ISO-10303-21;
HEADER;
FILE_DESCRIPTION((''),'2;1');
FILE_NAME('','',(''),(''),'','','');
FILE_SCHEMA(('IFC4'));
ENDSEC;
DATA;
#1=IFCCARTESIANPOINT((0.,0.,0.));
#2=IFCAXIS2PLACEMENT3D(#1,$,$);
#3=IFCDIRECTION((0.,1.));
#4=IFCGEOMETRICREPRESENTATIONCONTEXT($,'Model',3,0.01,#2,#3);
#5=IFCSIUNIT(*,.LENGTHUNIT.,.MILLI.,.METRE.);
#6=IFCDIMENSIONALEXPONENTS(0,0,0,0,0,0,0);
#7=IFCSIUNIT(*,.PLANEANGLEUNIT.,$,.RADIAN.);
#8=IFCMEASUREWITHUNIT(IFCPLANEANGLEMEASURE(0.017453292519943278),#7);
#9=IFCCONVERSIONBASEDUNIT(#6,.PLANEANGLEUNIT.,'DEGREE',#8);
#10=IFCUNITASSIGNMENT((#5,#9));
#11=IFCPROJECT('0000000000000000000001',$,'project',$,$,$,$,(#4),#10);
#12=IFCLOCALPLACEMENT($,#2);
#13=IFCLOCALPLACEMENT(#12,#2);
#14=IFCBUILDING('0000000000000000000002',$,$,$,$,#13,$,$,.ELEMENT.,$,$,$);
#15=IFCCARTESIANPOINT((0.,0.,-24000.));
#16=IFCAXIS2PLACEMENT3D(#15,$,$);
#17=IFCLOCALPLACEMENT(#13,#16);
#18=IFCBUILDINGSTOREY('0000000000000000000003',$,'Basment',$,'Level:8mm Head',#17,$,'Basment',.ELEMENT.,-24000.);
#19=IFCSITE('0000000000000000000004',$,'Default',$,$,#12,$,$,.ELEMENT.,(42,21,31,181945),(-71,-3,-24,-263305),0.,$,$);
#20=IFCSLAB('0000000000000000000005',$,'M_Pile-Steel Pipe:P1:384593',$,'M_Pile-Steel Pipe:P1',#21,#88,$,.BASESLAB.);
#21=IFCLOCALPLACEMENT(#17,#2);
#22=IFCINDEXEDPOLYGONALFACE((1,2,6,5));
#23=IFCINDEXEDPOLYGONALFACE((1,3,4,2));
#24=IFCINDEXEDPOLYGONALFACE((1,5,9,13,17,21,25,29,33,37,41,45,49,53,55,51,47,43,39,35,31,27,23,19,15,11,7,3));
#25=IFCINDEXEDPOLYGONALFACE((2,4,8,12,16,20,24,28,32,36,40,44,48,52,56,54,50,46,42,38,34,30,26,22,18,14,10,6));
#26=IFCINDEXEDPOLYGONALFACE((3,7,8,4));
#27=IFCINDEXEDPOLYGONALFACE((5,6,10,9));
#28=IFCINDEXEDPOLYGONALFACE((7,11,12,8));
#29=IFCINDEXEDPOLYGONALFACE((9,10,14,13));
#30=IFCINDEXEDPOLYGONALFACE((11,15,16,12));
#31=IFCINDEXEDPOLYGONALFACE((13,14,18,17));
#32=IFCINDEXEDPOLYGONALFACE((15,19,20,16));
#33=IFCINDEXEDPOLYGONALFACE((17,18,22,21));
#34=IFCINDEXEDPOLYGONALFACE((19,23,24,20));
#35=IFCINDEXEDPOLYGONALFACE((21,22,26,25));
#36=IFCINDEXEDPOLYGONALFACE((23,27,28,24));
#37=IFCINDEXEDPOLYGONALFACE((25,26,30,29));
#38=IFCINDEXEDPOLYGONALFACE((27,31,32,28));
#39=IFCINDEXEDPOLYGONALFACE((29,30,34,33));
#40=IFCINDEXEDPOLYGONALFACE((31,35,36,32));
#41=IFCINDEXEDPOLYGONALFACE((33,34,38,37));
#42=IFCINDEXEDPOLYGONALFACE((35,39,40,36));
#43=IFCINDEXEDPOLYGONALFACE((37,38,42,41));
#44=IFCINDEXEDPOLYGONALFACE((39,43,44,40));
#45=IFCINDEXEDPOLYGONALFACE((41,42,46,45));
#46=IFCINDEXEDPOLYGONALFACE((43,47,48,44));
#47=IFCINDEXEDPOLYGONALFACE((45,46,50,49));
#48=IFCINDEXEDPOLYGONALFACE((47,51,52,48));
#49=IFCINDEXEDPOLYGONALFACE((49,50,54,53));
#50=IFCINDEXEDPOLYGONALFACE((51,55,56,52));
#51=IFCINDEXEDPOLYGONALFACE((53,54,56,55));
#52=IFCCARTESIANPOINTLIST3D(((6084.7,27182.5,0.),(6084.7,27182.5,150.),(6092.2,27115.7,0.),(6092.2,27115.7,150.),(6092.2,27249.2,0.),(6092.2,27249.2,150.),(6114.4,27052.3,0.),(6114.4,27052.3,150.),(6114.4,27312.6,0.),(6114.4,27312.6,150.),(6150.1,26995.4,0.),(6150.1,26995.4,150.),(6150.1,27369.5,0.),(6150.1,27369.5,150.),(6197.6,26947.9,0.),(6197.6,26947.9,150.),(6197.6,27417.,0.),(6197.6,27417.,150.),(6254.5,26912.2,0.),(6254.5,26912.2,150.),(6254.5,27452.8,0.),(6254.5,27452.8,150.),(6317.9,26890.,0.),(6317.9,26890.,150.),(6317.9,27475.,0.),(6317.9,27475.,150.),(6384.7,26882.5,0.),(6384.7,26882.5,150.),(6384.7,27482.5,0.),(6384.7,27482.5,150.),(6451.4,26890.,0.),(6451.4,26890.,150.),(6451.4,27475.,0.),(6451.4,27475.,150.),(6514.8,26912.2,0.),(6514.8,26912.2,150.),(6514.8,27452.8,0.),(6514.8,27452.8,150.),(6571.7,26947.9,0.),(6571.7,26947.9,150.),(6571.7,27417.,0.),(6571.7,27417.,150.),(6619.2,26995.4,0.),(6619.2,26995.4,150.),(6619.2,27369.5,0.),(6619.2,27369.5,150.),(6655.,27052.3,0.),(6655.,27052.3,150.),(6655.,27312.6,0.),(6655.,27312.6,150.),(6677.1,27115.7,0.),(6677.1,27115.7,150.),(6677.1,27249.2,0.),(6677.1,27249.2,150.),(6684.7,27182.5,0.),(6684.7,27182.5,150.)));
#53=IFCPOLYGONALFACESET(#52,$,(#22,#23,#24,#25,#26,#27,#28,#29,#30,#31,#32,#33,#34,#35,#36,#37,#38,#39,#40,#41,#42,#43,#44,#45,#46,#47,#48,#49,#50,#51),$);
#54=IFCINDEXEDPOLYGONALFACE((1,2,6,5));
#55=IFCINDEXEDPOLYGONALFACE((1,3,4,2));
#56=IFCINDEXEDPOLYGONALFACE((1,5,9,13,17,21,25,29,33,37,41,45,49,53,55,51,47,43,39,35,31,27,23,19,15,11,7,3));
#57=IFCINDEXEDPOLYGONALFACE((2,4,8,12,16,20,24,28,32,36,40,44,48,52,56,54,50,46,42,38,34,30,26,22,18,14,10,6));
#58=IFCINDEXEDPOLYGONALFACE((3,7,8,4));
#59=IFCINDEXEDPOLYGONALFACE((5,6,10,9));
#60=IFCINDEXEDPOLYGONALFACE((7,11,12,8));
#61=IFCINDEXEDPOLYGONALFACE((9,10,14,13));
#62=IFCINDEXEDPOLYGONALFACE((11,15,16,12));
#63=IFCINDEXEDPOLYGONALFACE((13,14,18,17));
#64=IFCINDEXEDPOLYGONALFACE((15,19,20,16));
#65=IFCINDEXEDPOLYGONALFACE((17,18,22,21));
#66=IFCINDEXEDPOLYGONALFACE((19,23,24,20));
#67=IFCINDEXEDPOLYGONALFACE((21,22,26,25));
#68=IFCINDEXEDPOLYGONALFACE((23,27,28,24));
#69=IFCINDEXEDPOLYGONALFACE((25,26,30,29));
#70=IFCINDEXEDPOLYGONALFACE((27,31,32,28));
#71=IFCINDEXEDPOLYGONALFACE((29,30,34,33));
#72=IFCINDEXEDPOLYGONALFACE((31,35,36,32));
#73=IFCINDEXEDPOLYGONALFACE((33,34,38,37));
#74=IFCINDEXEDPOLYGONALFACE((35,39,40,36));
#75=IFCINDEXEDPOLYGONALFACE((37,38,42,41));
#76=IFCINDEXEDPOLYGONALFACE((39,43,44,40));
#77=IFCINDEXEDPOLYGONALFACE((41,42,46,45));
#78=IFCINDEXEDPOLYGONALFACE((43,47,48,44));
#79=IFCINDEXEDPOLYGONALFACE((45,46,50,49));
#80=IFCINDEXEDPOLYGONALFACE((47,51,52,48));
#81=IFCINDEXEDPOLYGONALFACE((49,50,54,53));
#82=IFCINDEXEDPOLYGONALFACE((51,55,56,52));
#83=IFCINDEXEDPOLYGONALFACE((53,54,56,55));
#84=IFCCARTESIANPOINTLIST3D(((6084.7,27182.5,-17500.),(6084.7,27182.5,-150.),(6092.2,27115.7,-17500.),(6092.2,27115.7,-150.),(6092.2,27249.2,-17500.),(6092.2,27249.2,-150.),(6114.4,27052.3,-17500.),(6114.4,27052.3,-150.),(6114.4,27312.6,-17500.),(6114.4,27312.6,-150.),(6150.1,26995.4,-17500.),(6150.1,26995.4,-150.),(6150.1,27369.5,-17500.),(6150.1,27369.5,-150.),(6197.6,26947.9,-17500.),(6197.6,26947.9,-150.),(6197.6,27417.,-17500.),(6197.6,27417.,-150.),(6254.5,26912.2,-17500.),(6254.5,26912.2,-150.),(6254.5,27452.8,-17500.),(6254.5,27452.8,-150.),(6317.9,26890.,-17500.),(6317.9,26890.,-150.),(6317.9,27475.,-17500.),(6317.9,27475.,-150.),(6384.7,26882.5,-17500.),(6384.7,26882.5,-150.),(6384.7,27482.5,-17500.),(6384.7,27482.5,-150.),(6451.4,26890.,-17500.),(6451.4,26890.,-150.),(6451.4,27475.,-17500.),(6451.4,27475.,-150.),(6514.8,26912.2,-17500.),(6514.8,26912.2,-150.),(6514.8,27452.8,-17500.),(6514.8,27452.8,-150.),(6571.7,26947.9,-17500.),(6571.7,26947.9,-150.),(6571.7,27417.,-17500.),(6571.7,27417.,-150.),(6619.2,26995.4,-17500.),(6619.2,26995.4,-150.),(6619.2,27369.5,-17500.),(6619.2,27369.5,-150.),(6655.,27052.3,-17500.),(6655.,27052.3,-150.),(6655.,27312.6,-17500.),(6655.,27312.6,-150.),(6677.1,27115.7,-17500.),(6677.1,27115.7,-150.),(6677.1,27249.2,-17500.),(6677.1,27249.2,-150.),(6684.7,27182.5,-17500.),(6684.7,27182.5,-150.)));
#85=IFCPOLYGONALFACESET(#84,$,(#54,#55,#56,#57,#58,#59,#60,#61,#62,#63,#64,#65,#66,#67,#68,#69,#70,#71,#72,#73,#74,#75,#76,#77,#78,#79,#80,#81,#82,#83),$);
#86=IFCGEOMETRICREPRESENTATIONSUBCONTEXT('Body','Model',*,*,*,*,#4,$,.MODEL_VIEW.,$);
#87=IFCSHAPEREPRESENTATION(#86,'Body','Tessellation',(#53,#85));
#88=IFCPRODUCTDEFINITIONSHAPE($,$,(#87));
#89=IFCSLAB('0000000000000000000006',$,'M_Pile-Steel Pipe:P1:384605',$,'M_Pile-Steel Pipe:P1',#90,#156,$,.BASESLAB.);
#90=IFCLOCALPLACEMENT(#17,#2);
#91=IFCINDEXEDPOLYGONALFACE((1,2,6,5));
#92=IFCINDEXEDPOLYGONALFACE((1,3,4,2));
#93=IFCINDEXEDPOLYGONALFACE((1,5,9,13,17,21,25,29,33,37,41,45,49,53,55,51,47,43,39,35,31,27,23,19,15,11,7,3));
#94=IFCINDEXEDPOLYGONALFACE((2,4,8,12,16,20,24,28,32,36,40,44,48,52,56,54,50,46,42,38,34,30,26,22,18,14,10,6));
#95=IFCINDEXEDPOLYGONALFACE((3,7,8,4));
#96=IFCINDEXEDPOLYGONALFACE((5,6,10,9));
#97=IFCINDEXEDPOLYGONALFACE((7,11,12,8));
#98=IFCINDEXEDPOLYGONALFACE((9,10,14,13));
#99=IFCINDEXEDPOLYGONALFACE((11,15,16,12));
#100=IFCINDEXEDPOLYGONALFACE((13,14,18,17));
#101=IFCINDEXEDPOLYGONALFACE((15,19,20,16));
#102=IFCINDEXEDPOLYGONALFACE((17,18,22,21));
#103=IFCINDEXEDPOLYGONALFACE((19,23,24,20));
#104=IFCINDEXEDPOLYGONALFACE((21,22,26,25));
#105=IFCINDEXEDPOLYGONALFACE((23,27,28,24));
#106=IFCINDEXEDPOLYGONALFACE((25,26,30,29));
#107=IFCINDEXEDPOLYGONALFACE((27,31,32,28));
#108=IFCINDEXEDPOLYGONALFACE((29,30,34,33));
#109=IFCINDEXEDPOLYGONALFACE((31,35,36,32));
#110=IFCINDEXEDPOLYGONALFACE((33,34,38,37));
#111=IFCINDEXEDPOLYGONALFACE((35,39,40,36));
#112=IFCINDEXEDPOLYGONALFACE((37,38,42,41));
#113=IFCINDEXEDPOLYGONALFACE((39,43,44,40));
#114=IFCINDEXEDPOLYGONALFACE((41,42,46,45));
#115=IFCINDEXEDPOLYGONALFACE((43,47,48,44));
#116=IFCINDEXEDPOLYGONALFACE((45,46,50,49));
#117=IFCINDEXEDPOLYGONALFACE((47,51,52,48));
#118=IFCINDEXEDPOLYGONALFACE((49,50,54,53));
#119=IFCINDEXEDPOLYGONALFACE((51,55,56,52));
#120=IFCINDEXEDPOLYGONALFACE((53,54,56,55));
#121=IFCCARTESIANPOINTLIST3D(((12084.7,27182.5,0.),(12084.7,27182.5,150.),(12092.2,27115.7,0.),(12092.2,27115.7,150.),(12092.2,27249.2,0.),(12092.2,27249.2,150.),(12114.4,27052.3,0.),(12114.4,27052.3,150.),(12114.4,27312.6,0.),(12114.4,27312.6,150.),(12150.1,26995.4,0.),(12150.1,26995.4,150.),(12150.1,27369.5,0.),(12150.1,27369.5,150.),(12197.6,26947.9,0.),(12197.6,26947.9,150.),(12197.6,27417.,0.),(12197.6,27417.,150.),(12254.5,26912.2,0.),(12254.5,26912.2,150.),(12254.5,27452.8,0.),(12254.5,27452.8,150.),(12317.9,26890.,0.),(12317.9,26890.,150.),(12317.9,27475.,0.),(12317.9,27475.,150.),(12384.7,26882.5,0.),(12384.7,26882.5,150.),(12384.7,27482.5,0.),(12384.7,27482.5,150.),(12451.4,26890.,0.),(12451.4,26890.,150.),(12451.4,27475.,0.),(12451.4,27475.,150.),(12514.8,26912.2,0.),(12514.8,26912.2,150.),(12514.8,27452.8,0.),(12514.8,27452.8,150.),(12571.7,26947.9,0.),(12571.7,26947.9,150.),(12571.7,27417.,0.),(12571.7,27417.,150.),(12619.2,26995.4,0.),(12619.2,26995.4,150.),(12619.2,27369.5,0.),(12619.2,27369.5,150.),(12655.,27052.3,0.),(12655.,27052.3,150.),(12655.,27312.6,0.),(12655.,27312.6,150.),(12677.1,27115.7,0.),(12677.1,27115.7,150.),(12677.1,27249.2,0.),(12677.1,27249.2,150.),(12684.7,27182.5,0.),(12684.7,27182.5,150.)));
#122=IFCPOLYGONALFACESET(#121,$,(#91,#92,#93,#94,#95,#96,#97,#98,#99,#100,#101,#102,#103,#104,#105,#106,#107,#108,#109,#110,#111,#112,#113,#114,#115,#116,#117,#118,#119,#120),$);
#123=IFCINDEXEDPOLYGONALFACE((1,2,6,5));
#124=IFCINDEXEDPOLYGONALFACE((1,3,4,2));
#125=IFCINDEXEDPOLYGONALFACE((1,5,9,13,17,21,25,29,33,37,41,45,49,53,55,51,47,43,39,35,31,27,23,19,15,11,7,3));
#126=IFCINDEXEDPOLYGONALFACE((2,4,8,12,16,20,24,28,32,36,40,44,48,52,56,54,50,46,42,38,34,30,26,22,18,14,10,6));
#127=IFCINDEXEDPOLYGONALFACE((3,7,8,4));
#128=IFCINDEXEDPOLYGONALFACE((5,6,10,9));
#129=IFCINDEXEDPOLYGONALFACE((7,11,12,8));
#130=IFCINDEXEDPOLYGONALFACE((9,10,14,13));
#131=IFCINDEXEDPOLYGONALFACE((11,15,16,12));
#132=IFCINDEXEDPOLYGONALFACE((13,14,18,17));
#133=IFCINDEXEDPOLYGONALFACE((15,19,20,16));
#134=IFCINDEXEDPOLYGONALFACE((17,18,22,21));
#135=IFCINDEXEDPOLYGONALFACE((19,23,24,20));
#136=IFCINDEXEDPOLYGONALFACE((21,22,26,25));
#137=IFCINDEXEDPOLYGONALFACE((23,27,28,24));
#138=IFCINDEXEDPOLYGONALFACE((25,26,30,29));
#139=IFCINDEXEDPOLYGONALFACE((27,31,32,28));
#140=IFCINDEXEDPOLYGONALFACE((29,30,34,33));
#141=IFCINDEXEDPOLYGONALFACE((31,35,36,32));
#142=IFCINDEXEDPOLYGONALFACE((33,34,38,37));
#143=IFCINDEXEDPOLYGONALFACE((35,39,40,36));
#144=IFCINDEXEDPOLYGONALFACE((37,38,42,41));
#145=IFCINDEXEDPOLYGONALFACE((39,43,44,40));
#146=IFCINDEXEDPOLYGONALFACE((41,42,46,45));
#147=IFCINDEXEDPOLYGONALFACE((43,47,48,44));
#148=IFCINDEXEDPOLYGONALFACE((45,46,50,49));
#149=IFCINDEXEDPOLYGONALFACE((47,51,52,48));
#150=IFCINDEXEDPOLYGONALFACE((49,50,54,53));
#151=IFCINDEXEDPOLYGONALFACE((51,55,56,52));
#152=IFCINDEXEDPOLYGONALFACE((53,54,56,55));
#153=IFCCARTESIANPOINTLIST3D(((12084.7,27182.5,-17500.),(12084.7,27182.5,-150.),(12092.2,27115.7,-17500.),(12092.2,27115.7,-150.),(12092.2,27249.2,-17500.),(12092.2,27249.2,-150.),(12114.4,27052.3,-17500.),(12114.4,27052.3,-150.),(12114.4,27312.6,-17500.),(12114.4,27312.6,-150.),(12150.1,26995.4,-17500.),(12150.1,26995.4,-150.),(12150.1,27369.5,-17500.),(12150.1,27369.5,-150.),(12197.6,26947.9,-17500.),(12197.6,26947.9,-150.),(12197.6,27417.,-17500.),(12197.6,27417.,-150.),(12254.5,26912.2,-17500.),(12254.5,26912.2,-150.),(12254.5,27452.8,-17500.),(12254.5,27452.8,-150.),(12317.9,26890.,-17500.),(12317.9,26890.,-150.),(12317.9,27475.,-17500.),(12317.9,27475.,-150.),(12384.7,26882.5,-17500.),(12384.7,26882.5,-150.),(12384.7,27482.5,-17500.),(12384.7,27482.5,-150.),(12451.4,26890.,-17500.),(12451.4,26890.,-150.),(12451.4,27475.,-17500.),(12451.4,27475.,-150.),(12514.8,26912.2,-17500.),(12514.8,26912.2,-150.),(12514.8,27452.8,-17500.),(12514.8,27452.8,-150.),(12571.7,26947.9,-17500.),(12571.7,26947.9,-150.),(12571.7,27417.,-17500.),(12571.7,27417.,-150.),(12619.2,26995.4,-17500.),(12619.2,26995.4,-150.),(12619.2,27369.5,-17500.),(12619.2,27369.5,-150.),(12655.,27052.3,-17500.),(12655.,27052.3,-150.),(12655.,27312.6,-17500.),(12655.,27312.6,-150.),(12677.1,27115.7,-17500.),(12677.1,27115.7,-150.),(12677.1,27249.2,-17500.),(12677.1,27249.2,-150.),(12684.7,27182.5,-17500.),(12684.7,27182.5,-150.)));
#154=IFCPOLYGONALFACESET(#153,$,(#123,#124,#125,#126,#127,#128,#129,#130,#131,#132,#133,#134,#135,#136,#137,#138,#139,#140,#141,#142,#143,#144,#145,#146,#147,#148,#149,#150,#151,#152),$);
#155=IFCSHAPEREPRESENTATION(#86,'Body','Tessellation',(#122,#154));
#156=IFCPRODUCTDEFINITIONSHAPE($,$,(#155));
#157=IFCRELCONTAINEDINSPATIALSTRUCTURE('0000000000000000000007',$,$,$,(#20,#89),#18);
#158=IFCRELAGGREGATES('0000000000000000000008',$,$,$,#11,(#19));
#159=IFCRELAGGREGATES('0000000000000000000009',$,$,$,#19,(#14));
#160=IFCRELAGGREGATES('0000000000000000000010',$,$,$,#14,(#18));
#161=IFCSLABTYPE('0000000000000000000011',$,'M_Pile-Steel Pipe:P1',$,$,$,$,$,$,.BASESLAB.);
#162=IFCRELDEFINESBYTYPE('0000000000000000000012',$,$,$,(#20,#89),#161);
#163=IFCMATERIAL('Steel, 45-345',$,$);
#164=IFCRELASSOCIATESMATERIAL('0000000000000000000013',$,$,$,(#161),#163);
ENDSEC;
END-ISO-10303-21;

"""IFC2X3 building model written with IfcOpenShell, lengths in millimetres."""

from ifc_helpers import new_model, entity, si_unit, converted_unit, direction, frame, frame_2d, origin, origin_2d_with_axis, place, context, subcontext, project, spatial, circle, extrude, material, type_object, element, save


model = new_model("IFC2X3")

# Units and contexts
model_context = context("Model", 3, precision=0.01, world=origin(), true_north=direction((0.0, 1.0)))
body_context = subcontext(model_context, "Body", "Model", "MODEL_VIEW")
ifc_project = project(units=[si_unit("LENGTHUNIT", "METRE", prefix="MILLI"), converted_unit("PLANEANGLEUNIT", "DEGREE", entity("IfcPlaneAngleMeasure", 0.017453292519943278), si_unit("PLANEANGLEUNIT", "RADIAN"), dimensions=[0, 0, 0, 0, 0, 0, 0])], contexts=[model_context])

# Site, building, storey
site_placement = place(None, origin())
site = spatial("IfcSite", under=ifc_project, at=site_placement, Name="Default", CompositionType="ELEMENT", RefLatitude=(42, 21, 31, 181945), RefLongitude=(-71, -3, -24, -263305), RefElevation=0.0)
building_placement = place(site_placement, origin())
building = spatial("IfcBuilding", under=site, at=building_placement, CompositionType="ELEMENT")
storey_placement = place(building_placement, frame((0.0, 0.0, -24000.0)))
storey = spatial("IfcBuildingStorey", under=building, at=storey_placement, Name="Basment", ObjectType="Level:8mm Head", LongName="Basment", CompositionType="ELEMENT", Elevation=-24000.0)

# Slabs
ifc_material_1 = material(Name="Steel, 45-345")
slab_type_1 = type_object("IfcSlabType", Name="M_Pile-Steel Pipe:P1", PredefinedType="BASESLAB", material=ifc_material_1)
slab_1_placement = place(storey_placement, origin())
element("IfcSlab", 1, at=slab_1_placement, inside=storey, type_object=slab_type_1, Name="M_Pile-Steel Pipe:P1:384593", ObjectType="M_Pile-Steel Pipe:P1", PredefinedType="BASESLAB", context=body_context, shape_type="SweptSolid", body=[
    extrude(circle(Radius=300.0, at=frame_2d((0.0, 0.0), x_axis=(1.0, 0.0))), frame((6384.7, 27182.5, 0.0), z_axis=(0.0, 0.0, 1.0), x_axis=(0.0, 1.0, 0.0)), (0.0, 0.0, 1.0), 150.0),
    extrude(circle(Radius=300.0, at=origin_2d_with_axis()), frame((6384.7, 27182.5, -17500.0), z_axis=(0.0, 0.0, 1.0), x_axis=(0.0, 1.0, 0.0)), (0.0, 0.0, 1.0), 17350.0),
])
slab_2_placement = place(storey_placement, origin())
element("IfcSlab", 2, at=slab_2_placement, inside=storey, type_object=slab_type_1, Name="M_Pile-Steel Pipe:P1:384605", ObjectType="M_Pile-Steel Pipe:P1", PredefinedType="BASESLAB", context=body_context, shape_type="SweptSolid", body=[
    extrude(circle(Radius=300.0, at=frame_2d((0.0, 0.0), x_axis=(1.0, 0.0))), frame((12384.7, 27182.5, 0.0), z_axis=(0.0, 0.0, 1.0), x_axis=(0.0, 1.0, 0.0)), (0.0, 0.0, 1.0), 150.0),
    extrude(circle(Radius=300.0, at=frame_2d((0.0, 0.0), x_axis=(1.0, 0.0))), frame((12384.7, 27182.5, -17500.0), z_axis=(0.0, 0.0, 1.0), x_axis=(0.0, 1.0, 0.0)), (0.0, 0.0, 1.0), 17350.0),
])

save(model, "model.ifc")
